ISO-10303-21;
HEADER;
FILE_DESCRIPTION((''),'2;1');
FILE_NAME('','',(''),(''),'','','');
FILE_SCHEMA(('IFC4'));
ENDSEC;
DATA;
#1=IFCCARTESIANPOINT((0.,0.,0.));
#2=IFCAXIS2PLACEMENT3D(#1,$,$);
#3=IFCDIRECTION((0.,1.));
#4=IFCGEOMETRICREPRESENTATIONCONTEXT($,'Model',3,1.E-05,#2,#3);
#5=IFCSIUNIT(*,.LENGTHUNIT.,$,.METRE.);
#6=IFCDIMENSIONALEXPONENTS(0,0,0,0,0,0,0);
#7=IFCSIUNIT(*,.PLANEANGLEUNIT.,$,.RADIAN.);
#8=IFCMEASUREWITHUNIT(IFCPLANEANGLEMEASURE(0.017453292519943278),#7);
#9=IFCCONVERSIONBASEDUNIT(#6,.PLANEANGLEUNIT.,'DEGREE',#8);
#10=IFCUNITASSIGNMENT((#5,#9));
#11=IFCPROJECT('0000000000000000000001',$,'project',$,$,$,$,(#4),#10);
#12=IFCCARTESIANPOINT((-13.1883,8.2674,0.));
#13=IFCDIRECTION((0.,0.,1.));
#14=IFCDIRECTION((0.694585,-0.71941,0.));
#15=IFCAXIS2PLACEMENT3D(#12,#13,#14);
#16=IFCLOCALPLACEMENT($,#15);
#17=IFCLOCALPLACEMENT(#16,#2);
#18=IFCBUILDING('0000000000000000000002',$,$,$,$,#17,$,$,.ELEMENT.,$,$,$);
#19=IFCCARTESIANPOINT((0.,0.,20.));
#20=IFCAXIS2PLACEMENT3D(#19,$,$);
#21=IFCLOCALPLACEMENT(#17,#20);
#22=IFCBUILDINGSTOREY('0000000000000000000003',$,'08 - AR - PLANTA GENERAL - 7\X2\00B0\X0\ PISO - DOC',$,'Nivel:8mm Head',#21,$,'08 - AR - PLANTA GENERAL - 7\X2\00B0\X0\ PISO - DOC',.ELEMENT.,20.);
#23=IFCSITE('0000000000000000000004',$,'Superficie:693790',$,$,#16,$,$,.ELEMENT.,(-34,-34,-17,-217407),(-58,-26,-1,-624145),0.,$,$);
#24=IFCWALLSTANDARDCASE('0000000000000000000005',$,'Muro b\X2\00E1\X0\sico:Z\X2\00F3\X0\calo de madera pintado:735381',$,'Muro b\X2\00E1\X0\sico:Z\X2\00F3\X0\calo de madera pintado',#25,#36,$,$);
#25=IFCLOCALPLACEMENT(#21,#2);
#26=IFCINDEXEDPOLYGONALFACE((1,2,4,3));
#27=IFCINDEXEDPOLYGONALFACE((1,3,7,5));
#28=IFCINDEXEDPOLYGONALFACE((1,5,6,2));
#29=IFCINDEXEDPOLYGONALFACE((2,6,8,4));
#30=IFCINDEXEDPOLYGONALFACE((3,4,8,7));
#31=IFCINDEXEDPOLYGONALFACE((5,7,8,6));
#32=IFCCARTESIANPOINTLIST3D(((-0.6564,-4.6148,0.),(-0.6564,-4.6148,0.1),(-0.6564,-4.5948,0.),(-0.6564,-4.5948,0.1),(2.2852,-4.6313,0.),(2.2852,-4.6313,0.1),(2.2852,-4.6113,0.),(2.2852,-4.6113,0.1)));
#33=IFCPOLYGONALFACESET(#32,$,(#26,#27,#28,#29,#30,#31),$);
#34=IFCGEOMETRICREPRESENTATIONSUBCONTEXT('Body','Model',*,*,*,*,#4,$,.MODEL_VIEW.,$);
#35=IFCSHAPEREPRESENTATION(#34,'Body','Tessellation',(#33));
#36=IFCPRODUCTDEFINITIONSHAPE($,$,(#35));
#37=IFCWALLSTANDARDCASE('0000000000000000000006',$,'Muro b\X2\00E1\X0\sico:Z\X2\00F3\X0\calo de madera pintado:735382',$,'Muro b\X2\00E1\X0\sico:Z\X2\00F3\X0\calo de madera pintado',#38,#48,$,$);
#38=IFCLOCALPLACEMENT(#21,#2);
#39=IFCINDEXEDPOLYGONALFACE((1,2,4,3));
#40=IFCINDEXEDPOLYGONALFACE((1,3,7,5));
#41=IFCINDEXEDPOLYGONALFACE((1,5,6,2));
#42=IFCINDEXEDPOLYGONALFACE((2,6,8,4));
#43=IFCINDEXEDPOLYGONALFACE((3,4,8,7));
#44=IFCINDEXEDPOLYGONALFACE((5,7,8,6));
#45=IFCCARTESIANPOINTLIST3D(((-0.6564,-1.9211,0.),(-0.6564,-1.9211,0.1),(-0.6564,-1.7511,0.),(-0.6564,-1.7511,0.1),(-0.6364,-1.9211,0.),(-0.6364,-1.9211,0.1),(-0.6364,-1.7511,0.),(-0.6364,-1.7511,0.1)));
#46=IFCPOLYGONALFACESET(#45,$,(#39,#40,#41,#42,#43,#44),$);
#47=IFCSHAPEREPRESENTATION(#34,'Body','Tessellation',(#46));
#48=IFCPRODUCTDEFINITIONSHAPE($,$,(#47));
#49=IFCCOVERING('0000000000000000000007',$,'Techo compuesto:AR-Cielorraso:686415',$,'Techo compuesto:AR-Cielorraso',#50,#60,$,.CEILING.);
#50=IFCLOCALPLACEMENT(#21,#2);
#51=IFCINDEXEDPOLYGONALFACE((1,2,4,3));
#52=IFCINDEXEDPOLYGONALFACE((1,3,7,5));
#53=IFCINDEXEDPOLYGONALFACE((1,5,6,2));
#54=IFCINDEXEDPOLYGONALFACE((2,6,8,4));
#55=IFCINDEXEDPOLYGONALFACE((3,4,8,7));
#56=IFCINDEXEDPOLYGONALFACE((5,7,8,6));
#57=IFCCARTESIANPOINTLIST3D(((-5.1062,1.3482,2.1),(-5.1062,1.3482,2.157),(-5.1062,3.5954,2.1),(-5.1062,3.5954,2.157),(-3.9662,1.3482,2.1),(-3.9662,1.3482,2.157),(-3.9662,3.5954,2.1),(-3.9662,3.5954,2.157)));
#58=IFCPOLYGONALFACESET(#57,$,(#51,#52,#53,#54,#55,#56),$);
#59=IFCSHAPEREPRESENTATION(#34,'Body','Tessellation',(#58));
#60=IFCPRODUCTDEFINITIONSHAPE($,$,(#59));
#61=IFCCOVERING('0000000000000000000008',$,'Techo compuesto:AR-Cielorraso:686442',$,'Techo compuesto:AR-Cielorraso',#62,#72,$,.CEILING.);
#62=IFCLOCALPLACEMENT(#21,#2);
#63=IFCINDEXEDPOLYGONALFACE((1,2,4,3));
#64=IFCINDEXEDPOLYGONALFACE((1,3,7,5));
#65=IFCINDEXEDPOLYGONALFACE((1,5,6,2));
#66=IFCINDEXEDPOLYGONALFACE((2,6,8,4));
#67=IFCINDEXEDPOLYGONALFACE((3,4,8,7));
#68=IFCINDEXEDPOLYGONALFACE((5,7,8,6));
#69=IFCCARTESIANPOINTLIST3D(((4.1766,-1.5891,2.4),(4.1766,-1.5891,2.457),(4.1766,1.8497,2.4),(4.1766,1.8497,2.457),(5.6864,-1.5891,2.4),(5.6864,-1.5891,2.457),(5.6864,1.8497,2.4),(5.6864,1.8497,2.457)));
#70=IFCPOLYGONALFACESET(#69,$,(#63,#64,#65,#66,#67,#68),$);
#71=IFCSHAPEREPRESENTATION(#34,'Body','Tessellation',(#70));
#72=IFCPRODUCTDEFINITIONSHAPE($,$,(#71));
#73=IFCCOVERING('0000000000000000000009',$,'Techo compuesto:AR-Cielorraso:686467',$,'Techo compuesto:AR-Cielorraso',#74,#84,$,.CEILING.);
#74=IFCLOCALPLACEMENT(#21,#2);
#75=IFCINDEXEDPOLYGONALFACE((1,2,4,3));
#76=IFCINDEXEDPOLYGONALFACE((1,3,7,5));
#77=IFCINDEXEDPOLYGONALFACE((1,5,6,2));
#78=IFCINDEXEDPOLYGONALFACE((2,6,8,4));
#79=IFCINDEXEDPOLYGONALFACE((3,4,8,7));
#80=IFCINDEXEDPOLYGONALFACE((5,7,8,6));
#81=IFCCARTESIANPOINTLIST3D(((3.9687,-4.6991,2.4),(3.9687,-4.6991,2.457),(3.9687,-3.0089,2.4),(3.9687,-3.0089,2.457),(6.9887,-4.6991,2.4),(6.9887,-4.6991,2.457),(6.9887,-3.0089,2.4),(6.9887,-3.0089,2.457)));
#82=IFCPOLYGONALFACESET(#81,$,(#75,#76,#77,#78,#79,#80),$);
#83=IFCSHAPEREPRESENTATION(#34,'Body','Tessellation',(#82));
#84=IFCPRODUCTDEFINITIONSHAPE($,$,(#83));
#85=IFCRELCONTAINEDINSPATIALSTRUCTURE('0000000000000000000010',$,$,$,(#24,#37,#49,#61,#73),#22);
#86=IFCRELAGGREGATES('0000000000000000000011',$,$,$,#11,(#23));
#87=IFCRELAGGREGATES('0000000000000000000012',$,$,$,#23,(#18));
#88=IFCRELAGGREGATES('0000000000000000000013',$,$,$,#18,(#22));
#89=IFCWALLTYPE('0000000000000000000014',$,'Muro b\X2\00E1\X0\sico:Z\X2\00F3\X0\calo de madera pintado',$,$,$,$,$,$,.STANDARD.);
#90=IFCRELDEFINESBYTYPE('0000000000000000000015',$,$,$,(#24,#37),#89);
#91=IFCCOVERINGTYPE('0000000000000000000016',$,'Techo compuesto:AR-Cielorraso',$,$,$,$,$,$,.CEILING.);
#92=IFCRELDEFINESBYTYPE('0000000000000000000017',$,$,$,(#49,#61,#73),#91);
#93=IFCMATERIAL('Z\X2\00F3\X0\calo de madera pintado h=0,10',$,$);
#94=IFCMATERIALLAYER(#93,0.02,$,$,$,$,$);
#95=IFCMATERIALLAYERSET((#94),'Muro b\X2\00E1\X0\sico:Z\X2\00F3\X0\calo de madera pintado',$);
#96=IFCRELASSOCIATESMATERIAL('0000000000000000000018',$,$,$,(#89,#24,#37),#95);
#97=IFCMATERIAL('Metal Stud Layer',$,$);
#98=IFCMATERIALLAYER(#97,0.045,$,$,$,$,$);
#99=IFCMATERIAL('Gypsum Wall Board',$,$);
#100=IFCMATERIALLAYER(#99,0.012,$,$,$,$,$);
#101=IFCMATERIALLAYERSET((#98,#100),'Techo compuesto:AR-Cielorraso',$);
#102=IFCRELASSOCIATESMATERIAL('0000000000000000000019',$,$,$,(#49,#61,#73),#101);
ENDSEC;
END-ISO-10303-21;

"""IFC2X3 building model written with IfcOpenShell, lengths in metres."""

from ifc_helpers import new_model, entity, si_unit, converted_unit, direction, frame, frame_2d, origin, place, context, subcontext, project, spatial, polyline, rectangle, outline, extrude, material, layer, layer_set, layer_usage, type_object, element, save


model = new_model("IFC2X3")

# Units and contexts
model_context = context("Model", 3, precision=1e-05, world=origin(), true_north=direction((0.0, 1.0)))
body_context = subcontext(model_context, "Body", "Model", "MODEL_VIEW")
ifc_project = project(units=[si_unit("LENGTHUNIT", "METRE"), converted_unit("PLANEANGLEUNIT", "DEGREE", entity("IfcPlaneAngleMeasure", 0.017453292519943278), si_unit("PLANEANGLEUNIT", "RADIAN"), dimensions=[0, 0, 0, 0, 0, 0, 0])], contexts=[model_context])

# Site, building, storey
site_placement = place(None, frame((-13.1883, 8.2674, 0.0), z_axis=(0.0, 0.0, 1.0), x_axis=(0.694585, -0.71941, 0.0)))
site = spatial("IfcSite", under=ifc_project, at=site_placement, Name="Superficie:693790", CompositionType="ELEMENT", RefLatitude=(-34, -34, -17, -217407), RefLongitude=(-58, -26, -1, -624145), RefElevation=0.0)
building_placement = place(site_placement, origin())
building = spatial("IfcBuilding", under=site, at=building_placement, CompositionType="ELEMENT")
storey_placement = place(building_placement, frame((0.0, 0.0, 20.0)))
storey = spatial("IfcBuildingStorey", under=building, at=storey_placement, Name="08 - AR - PLANTA GENERAL - 7° PISO - DOC", ObjectType="Nivel:8mm Head", LongName="08 - AR - PLANTA GENERAL - 7° PISO - DOC", CompositionType="ELEMENT", Elevation=20.0)

# Walls
ifc_material_1 = material(Name="Zócalo de madera pintado h=0,10")
ifc_layer_1 = layer(ifc_material_1, 0.02)
ifc_layer_set_1 = layer_set([ifc_layer_1], Name="Muro básico:Zócalo de madera pintado")
wall_type_1 = type_object("IfcWallType", Name="Muro básico:Zócalo de madera pintado", PredefinedType="STANDARD", material=ifc_layer_set_1)
ifc_layer_usage_1 = layer_usage(ifc_layer_set_1, "AXIS2", "NEGATIVE", 0.01)
wall_1_placement = place(storey_placement, frame((-0.6565, -4.6048, 0.0), z_axis=(0.0, 0.0, 1.0), x_axis=(0.999984, -0.005619, 0.0)))
element("IfcWallStandardCase", 1, at=wall_1_placement, inside=storey, type_object=wall_type_1, material=ifc_layer_usage_1, Name="Muro básico:Zócalo de madera pintado:735381", ObjectType="Muro básico:Zócalo de madera pintado", context=body_context, shape_type="SweptSolid", body=[
    extrude(outline(polyline([(2.9417, -0.01), (2.9416, 0.01), (0.0, 0.01), (0.0001, -0.01), (2.9417, -0.01)])), origin(), (0.0, 0.0, 1.0), 0.1),
])
ifc_layer_usage_2 = layer_usage(ifc_layer_set_1, "AXIS2", "NEGATIVE", 0.01)
wall_2_placement = place(storey_placement, frame((-0.6464, -1.7511, 0.0), z_axis=(0.0, 0.0, 1.0), x_axis=(0.0, -1.0, 0.0)))
element("IfcWallStandardCase", 2, at=wall_2_placement, inside=storey, type_object=wall_type_1, material=ifc_layer_usage_2, Name="Muro básico:Zócalo de madera pintado:735382", ObjectType="Muro básico:Zócalo de madera pintado", context=body_context, shape_type="SweptSolid", body=[
    extrude(rectangle(XDim=0.17, YDim=0.02, at=frame_2d((0.085, 0.0), x_axis=(-1.0, 0.0))), origin(), (0.0, 0.0, 1.0), 0.1),
])

# Coverings
ifc_material_2 = material(Name="Metal Stud Layer")
ifc_layer_2 = layer(ifc_material_2, 0.045)
ifc_material_3 = material(Name="Gypsum Wall Board")
ifc_layer_3 = layer(ifc_material_3, 0.012)
ifc_layer_set_2 = layer_set([ifc_layer_2, ifc_layer_3], Name="Techo compuesto:AR-Cielorraso")
covering_type = type_object("IfcCoveringType", Name="Techo compuesto:AR-Cielorraso", PredefinedType="CEILING")
ifc_layer_usage_3 = layer_usage(ifc_layer_set_2, "AXIS3", "NEGATIVE", 0.057)
covering_1_placement = place(storey_placement, origin())
element("IfcCovering", 3, at=covering_1_placement, inside=storey, type_object=covering_type, material=ifc_layer_usage_3, Name="Techo compuesto:AR-Cielorraso:686415", ObjectType="Techo compuesto:AR-Cielorraso", PredefinedType="CEILING", context=body_context, shape_type="SweptSolid", body=[
    extrude(rectangle(XDim=1.14, YDim=2.2473, at=frame_2d((0.0, 0.0), x_axis=(1.0, 0.0))), frame((-4.5362, 2.4718, 2.1), z_axis=(0.0, 0.0, 1.0), x_axis=(-1.0, 0.0, 0.0)), (0.0, 0.0, 1.0), 0.057),
])
ifc_layer_usage_4 = layer_usage(ifc_layer_set_2, "AXIS3", "NEGATIVE", 0.057)
covering_2_placement = place(storey_placement, origin())
element("IfcCovering", 4, at=covering_2_placement, inside=storey, type_object=covering_type, material=ifc_layer_usage_4, Name="Techo compuesto:AR-Cielorraso:686442", ObjectType="Techo compuesto:AR-Cielorraso", PredefinedType="CEILING", context=body_context, shape_type="SweptSolid", body=[
    extrude(rectangle(XDim=1.5098, YDim=3.4387, at=frame_2d((0.0, 0.0), x_axis=(1.0, 0.0))), frame((4.9315, 0.1303, 2.4), z_axis=(0.0, 0.0, 1.0), x_axis=(-1.0, 0.0, 0.0)), (0.0, 0.0, 1.0), 0.057),
])
ifc_layer_usage_5 = layer_usage(ifc_layer_set_2, "AXIS3", "NEGATIVE", 0.057)
covering_3_placement = place(storey_placement, origin())
element("IfcCovering", 5, at=covering_3_placement, inside=storey, type_object=covering_type, material=ifc_layer_usage_5, Name="Techo compuesto:AR-Cielorraso:686467", ObjectType="Techo compuesto:AR-Cielorraso", PredefinedType="CEILING", context=body_context, shape_type="SweptSolid", body=[
    extrude(rectangle(XDim=3.02, YDim=1.6902, at=frame_2d((0.0, 0.0), x_axis=(1.0, 0.0))), frame((5.4787, -3.854, 2.4), z_axis=(0.0, 0.0, 1.0), x_axis=(-1.0, 0.0, 0.0)), (0.0, 0.0, 1.0), 0.057),
])

save(model, "model.ifc")
